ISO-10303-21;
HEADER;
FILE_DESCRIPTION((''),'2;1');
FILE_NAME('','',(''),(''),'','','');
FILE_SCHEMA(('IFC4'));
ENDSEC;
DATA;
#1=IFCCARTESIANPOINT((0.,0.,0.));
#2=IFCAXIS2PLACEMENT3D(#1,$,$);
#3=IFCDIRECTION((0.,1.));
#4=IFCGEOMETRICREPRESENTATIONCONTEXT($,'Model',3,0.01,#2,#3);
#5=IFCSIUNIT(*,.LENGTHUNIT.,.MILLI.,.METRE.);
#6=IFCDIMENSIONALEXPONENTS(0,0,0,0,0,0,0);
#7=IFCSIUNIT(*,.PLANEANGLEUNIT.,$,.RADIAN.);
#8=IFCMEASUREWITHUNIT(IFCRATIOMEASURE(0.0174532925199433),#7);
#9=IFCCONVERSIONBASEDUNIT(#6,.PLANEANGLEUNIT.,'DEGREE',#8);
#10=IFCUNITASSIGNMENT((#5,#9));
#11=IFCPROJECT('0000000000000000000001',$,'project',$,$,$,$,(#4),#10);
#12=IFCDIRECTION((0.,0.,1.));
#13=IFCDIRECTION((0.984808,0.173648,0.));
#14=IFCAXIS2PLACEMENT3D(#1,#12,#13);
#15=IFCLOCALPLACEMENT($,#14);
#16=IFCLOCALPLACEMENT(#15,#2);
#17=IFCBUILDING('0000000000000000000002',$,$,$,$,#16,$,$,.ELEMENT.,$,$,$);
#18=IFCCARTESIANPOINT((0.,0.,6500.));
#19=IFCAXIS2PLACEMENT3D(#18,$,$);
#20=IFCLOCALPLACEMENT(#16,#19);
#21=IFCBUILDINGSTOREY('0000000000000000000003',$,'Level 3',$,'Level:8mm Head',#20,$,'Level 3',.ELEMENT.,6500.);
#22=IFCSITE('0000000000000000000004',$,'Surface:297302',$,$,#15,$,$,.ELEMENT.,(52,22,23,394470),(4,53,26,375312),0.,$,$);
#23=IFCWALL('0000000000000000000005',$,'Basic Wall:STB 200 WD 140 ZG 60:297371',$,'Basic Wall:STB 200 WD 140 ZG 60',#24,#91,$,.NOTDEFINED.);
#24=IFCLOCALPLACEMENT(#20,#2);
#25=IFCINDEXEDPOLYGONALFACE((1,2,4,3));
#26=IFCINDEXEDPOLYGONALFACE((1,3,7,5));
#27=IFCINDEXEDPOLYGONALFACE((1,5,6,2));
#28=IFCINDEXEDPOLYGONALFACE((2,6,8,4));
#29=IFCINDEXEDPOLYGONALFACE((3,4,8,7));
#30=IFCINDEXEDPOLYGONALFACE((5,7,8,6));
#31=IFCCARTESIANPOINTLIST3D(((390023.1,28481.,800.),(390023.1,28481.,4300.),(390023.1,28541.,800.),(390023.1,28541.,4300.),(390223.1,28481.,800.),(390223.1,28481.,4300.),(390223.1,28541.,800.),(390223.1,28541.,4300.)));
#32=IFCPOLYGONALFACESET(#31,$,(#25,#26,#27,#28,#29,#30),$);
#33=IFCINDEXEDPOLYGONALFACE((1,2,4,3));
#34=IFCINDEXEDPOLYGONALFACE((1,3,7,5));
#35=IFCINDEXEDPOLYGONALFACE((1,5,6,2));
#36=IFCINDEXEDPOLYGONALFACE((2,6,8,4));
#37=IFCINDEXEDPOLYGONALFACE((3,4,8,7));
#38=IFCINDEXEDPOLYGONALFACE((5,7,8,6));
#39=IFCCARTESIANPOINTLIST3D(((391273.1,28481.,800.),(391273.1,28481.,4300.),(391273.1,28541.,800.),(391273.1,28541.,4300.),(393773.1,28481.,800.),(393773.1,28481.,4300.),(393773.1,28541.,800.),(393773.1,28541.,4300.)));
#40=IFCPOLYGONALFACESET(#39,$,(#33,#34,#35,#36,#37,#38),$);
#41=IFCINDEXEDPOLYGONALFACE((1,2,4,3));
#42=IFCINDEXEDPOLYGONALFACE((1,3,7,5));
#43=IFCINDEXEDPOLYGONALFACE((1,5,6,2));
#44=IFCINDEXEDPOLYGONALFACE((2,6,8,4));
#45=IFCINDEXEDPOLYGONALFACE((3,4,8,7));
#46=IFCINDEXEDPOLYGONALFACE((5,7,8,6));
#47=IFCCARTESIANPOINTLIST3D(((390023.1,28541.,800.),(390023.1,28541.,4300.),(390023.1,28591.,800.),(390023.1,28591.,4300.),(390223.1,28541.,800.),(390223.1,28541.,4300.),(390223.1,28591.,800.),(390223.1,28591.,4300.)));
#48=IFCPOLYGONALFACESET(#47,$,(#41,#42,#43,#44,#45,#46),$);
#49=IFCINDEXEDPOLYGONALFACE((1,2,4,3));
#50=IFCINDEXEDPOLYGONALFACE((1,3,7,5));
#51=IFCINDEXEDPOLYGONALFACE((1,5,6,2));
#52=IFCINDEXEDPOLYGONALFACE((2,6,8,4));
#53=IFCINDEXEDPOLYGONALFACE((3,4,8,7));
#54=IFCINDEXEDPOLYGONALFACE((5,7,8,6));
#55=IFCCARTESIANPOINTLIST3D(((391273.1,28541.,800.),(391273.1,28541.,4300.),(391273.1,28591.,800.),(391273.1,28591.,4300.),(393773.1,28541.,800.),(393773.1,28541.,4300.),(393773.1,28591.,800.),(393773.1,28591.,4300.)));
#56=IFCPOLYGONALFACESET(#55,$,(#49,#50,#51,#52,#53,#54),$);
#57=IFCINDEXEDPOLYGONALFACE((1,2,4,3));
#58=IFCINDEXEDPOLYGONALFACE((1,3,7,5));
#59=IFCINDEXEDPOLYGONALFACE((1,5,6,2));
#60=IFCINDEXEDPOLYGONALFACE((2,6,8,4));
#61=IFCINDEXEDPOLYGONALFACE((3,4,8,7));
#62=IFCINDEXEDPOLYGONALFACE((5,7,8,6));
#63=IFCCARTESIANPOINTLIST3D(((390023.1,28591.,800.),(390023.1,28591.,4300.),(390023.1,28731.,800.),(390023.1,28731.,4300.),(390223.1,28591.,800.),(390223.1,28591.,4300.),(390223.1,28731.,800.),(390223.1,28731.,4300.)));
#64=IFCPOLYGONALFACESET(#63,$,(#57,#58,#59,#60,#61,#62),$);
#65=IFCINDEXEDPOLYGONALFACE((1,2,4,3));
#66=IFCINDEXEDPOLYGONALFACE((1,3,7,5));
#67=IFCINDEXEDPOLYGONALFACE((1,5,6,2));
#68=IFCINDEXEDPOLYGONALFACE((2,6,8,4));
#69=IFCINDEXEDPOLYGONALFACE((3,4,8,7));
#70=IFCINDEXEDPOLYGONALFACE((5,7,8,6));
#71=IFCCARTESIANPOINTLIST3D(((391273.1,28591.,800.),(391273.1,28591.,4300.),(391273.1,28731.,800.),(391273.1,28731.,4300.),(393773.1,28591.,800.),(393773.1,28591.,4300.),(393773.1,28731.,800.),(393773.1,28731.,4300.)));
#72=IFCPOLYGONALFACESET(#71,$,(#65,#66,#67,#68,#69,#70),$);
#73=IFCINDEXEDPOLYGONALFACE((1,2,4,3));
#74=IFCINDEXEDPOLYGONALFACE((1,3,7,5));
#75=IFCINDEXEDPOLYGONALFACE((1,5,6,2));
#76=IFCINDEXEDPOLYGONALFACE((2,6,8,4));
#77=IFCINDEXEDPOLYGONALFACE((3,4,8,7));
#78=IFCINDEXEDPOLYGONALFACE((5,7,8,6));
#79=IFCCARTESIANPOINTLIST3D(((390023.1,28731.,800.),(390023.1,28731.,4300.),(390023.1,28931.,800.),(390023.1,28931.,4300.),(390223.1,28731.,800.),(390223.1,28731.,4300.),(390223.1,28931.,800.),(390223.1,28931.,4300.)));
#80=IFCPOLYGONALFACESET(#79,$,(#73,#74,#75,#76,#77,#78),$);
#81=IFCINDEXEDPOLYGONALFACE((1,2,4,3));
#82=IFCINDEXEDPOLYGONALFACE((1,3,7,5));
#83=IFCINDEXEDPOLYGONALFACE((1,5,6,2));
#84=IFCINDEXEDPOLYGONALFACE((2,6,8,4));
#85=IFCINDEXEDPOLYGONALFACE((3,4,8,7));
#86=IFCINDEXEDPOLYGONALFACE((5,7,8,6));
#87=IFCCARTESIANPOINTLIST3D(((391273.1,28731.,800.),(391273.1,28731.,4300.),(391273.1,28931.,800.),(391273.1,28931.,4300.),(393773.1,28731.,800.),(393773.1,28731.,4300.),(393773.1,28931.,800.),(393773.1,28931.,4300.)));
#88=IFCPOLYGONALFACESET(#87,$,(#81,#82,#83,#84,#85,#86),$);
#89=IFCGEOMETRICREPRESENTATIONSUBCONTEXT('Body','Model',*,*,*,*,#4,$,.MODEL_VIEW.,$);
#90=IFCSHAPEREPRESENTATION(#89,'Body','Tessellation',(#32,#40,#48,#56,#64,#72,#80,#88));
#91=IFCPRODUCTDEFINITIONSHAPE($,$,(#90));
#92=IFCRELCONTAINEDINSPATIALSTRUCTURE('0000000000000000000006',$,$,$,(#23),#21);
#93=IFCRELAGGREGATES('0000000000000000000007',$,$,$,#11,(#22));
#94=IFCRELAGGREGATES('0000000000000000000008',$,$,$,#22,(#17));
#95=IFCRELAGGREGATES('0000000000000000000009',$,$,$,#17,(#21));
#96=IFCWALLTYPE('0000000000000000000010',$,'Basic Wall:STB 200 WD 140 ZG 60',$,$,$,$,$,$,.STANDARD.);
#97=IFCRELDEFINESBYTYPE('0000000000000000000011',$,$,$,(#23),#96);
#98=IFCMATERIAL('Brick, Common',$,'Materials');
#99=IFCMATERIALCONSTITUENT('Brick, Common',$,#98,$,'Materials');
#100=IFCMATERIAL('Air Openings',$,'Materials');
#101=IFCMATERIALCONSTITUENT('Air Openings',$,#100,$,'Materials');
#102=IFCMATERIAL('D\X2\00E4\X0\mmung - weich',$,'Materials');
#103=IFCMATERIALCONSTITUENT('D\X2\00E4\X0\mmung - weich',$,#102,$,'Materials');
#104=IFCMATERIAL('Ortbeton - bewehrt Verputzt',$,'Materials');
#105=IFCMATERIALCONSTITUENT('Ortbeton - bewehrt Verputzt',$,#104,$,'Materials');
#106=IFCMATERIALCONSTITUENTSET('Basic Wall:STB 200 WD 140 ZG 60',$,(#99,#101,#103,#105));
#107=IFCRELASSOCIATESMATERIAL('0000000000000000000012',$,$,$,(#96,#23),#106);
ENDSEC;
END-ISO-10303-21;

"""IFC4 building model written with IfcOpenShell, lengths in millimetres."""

from ifc_helpers import new_model, entity, si_unit, converted_unit, direction, frame, origin, place, context, subcontext, project, spatial, indexed_curve, outline, extrude, material, constituent, constituent_set, type_object, element, save


model = new_model("IFC4")

# Units and contexts
model_context = context("Model", 3, precision=0.01, world=origin(), true_north=direction((0.0, 1.0)))
body_context = subcontext(model_context, "Body", "Model", "MODEL_VIEW")
ifc_project = project(units=[si_unit("LENGTHUNIT", "METRE", prefix="MILLI"), converted_unit("PLANEANGLEUNIT", "DEGREE", entity("IfcRatioMeasure", 0.0174532925199433), si_unit("PLANEANGLEUNIT", "RADIAN"), dimensions=[0, 0, 0, 0, 0, 0, 0])], contexts=[model_context])

# Site, building, storey
site_placement = place(None, frame((0.0, 0.0, 0.0), z_axis=(0.0, 0.0, 1.0), x_axis=(0.984808, 0.173648, 0.0)))
site = spatial("IfcSite", under=ifc_project, at=site_placement, Name="Surface:297302", CompositionType="ELEMENT", RefLatitude=(52, 22, 23, 394470), RefLongitude=(4, 53, 26, 375312), RefElevation=0.0)
building_placement = place(site_placement, origin())
building = spatial("IfcBuilding", under=site, at=building_placement, CompositionType="ELEMENT")
storey_placement = place(building_placement, frame((0.0, 0.0, 6500.0)))
storey = spatial("IfcBuildingStorey", under=building, at=storey_placement, Name="Level 3", ObjectType="Level:8mm Head", LongName="Level 3", CompositionType="ELEMENT", Elevation=6500.0)

# Wall, openings
ifc_material_1 = material(Name="Brick, Common", Category="Materials")
ifc_constituent_1 = constituent(ifc_material_1, Name="Brick, Common", Category="Materials")
ifc_material_2 = material(Name="Air Openings", Category="Materials")
ifc_constituent_2 = constituent(ifc_material_2, Name="Air Openings", Category="Materials")
ifc_material_3 = material(Name="Dämmung - weich", Category="Materials")
ifc_constituent_3 = constituent(ifc_material_3, Name="Dämmung - weich", Category="Materials")
ifc_material_4 = material(Name="Ortbeton - bewehrt Verputzt", Category="Materials")
ifc_constituent_4 = constituent(ifc_material_4, Name="Ortbeton - bewehrt Verputzt", Category="Materials")
ifc_constituent_set_1 = constituent_set(constituents=[ifc_constituent_1, ifc_constituent_2, ifc_constituent_3, ifc_constituent_4], Name="Basic Wall:STB 200 WD 140 ZG 60")
wall_type = type_object("IfcWallType", Name="Basic Wall:STB 200 WD 140 ZG 60", PredefinedType="STANDARD", material=ifc_constituent_set_1)
wall_placement = place(storey_placement, frame((393773.1, 28706.0, 800.0), z_axis=(0.0, 0.0, 1.0), x_axis=(-1.0, 0.0, 0.0)))
wall = element("IfcWall", 1, at=wall_placement, inside=storey, type_object=wall_type, material=ifc_constituent_set_1, Name="Basic Wall:STB 200 WD 140 ZG 60:297371", ObjectType="Basic Wall:STB 200 WD 140 ZG 60", PredefinedType="NOTDEFINED", context=body_context, shape_type="SweptSolid", body=[
    extrude(outline(indexed_curve([(-30.0, -100.0), (30.0, -100.0), (30.0, 100.0), (-30.0, 100.0), (-30.0, -100.0)], self_intersect=False)), frame((3650.0, 195.0, 0.0), z_axis=(0.0, 0.0, 1.0), x_axis=(0.0, -1.0, 0.0)), (0.0, 0.0, 1.0), 3500.0),
    extrude(outline(indexed_curve([(-30.0, -1250.0), (30.0, -1250.0), (30.0, 1250.0), (-30.0, 1250.0), (-30.0, -1250.0)], self_intersect=False)), frame((1250.0, 195.0, 0.0), z_axis=(0.0, 0.0, 1.0), x_axis=(0.0, -1.0, 0.0)), (0.0, 0.0, 1.0), 3500.0),
    extrude(outline(indexed_curve([(-100.0, -25.0), (100.0, -25.0), (100.0, 25.0), (-100.0, 25.0), (-100.0, -25.0)], self_intersect=False)), frame((3650.0, 140.0, 0.0), z_axis=(0.0, 0.0, 1.0), x_axis=(-1.0, 0.0, 0.0)), (0.0, 0.0, 1.0), 3500.0),
    extrude(outline(indexed_curve([(-1250.0, -25.0), (1250.0, -25.0), (1250.0, 25.0), (-1250.0, 25.0), (-1250.0, -25.0)], self_intersect=False)), frame((1250.0, 140.0, 0.0), z_axis=(0.0, 0.0, 1.0), x_axis=(-1.0, 0.0, 0.0)), (0.0, 0.0, 1.0), 3500.0),
    extrude(outline(indexed_curve([(-100.0, -70.0), (100.0, -70.0), (100.0, 70.0), (-100.0, 70.0), (-100.0, -70.0)], self_intersect=False)), frame((3650.0, 45.0, 0.0), z_axis=(0.0, 0.0, 1.0), x_axis=(-1.0, 0.0, 0.0)), (0.0, 0.0, 1.0), 3500.0),
    extrude(outline(indexed_curve([(-1250.0, -70.0), (1250.0, -70.0), (1250.0, 70.0), (-1250.0, 70.0), (-1250.0, -70.0)], self_intersect=False)), frame((1250.0, 45.0, 0.0), z_axis=(0.0, 0.0, 1.0), x_axis=(-1.0, 0.0, 0.0)), (0.0, 0.0, 1.0), 3500.0),
    extrude(outline(indexed_curve([(-100.0, -100.0), (100.0, -100.0), (100.0, 100.0), (-100.0, 100.0), (-100.0, -100.0)], self_intersect=False)), frame((3650.0, -125.0, 0.0), z_axis=(0.0, 0.0, 1.0), x_axis=(0.0, 1.0, 0.0)), (0.0, 0.0, 1.0), 3500.0),
    extrude(outline(indexed_curve([(-100.0, -1250.0), (100.0, -1250.0), (100.0, 1250.0), (-100.0, 1250.0), (-100.0, -1250.0)], self_intersect=False)), frame((1250.0, -125.0, 0.0), z_axis=(0.0, 0.0, 1.0), x_axis=(0.0, 1.0, 0.0)), (0.0, 0.0, 1.0), 3500.0),
])
opening_1_placement = place(wall_placement, frame((2500.0, -225.0, 0.0)))
element("IfcOpeningElement", 2, at=opening_1_placement, cuts=wall, PredefinedType="OPENING", context=body_context, shape_type="SweptSolid", body=[
    extrude(outline(indexed_curve([(3500.0, 1050.0), (0.0, 1050.0), (0.0, 0.0), (3500.0, 0.0), (3500.0, 1050.0)], self_intersect=False)), frame((0.0, 0.0, 0.0), z_axis=(0.0, 1.0, 0.0), x_axis=(0.0, 0.0, 1.0)), (0.0, 0.0, 1.0), 450.0),
])
opening_2_placement = place(wall_placement, frame((-1050.0, -225.0, 0.0)))
element("IfcOpeningElement", 3, at=opening_2_placement, cuts=wall, PredefinedType="OPENING", context=body_context, shape_type="SweptSolid", body=[
    extrude(outline(indexed_curve([(3500.0, 1050.0), (0.0, 1050.0), (0.0, 0.0), (3500.0, 0.0), (3500.0, 1050.0)], self_intersect=False)), frame((0.0, 0.0, 0.0), z_axis=(0.0, 1.0, 0.0), x_axis=(0.0, 0.0, 1.0)), (0.0, 0.0, 1.0), 450.0),
])

save(model, "model.ifc")
